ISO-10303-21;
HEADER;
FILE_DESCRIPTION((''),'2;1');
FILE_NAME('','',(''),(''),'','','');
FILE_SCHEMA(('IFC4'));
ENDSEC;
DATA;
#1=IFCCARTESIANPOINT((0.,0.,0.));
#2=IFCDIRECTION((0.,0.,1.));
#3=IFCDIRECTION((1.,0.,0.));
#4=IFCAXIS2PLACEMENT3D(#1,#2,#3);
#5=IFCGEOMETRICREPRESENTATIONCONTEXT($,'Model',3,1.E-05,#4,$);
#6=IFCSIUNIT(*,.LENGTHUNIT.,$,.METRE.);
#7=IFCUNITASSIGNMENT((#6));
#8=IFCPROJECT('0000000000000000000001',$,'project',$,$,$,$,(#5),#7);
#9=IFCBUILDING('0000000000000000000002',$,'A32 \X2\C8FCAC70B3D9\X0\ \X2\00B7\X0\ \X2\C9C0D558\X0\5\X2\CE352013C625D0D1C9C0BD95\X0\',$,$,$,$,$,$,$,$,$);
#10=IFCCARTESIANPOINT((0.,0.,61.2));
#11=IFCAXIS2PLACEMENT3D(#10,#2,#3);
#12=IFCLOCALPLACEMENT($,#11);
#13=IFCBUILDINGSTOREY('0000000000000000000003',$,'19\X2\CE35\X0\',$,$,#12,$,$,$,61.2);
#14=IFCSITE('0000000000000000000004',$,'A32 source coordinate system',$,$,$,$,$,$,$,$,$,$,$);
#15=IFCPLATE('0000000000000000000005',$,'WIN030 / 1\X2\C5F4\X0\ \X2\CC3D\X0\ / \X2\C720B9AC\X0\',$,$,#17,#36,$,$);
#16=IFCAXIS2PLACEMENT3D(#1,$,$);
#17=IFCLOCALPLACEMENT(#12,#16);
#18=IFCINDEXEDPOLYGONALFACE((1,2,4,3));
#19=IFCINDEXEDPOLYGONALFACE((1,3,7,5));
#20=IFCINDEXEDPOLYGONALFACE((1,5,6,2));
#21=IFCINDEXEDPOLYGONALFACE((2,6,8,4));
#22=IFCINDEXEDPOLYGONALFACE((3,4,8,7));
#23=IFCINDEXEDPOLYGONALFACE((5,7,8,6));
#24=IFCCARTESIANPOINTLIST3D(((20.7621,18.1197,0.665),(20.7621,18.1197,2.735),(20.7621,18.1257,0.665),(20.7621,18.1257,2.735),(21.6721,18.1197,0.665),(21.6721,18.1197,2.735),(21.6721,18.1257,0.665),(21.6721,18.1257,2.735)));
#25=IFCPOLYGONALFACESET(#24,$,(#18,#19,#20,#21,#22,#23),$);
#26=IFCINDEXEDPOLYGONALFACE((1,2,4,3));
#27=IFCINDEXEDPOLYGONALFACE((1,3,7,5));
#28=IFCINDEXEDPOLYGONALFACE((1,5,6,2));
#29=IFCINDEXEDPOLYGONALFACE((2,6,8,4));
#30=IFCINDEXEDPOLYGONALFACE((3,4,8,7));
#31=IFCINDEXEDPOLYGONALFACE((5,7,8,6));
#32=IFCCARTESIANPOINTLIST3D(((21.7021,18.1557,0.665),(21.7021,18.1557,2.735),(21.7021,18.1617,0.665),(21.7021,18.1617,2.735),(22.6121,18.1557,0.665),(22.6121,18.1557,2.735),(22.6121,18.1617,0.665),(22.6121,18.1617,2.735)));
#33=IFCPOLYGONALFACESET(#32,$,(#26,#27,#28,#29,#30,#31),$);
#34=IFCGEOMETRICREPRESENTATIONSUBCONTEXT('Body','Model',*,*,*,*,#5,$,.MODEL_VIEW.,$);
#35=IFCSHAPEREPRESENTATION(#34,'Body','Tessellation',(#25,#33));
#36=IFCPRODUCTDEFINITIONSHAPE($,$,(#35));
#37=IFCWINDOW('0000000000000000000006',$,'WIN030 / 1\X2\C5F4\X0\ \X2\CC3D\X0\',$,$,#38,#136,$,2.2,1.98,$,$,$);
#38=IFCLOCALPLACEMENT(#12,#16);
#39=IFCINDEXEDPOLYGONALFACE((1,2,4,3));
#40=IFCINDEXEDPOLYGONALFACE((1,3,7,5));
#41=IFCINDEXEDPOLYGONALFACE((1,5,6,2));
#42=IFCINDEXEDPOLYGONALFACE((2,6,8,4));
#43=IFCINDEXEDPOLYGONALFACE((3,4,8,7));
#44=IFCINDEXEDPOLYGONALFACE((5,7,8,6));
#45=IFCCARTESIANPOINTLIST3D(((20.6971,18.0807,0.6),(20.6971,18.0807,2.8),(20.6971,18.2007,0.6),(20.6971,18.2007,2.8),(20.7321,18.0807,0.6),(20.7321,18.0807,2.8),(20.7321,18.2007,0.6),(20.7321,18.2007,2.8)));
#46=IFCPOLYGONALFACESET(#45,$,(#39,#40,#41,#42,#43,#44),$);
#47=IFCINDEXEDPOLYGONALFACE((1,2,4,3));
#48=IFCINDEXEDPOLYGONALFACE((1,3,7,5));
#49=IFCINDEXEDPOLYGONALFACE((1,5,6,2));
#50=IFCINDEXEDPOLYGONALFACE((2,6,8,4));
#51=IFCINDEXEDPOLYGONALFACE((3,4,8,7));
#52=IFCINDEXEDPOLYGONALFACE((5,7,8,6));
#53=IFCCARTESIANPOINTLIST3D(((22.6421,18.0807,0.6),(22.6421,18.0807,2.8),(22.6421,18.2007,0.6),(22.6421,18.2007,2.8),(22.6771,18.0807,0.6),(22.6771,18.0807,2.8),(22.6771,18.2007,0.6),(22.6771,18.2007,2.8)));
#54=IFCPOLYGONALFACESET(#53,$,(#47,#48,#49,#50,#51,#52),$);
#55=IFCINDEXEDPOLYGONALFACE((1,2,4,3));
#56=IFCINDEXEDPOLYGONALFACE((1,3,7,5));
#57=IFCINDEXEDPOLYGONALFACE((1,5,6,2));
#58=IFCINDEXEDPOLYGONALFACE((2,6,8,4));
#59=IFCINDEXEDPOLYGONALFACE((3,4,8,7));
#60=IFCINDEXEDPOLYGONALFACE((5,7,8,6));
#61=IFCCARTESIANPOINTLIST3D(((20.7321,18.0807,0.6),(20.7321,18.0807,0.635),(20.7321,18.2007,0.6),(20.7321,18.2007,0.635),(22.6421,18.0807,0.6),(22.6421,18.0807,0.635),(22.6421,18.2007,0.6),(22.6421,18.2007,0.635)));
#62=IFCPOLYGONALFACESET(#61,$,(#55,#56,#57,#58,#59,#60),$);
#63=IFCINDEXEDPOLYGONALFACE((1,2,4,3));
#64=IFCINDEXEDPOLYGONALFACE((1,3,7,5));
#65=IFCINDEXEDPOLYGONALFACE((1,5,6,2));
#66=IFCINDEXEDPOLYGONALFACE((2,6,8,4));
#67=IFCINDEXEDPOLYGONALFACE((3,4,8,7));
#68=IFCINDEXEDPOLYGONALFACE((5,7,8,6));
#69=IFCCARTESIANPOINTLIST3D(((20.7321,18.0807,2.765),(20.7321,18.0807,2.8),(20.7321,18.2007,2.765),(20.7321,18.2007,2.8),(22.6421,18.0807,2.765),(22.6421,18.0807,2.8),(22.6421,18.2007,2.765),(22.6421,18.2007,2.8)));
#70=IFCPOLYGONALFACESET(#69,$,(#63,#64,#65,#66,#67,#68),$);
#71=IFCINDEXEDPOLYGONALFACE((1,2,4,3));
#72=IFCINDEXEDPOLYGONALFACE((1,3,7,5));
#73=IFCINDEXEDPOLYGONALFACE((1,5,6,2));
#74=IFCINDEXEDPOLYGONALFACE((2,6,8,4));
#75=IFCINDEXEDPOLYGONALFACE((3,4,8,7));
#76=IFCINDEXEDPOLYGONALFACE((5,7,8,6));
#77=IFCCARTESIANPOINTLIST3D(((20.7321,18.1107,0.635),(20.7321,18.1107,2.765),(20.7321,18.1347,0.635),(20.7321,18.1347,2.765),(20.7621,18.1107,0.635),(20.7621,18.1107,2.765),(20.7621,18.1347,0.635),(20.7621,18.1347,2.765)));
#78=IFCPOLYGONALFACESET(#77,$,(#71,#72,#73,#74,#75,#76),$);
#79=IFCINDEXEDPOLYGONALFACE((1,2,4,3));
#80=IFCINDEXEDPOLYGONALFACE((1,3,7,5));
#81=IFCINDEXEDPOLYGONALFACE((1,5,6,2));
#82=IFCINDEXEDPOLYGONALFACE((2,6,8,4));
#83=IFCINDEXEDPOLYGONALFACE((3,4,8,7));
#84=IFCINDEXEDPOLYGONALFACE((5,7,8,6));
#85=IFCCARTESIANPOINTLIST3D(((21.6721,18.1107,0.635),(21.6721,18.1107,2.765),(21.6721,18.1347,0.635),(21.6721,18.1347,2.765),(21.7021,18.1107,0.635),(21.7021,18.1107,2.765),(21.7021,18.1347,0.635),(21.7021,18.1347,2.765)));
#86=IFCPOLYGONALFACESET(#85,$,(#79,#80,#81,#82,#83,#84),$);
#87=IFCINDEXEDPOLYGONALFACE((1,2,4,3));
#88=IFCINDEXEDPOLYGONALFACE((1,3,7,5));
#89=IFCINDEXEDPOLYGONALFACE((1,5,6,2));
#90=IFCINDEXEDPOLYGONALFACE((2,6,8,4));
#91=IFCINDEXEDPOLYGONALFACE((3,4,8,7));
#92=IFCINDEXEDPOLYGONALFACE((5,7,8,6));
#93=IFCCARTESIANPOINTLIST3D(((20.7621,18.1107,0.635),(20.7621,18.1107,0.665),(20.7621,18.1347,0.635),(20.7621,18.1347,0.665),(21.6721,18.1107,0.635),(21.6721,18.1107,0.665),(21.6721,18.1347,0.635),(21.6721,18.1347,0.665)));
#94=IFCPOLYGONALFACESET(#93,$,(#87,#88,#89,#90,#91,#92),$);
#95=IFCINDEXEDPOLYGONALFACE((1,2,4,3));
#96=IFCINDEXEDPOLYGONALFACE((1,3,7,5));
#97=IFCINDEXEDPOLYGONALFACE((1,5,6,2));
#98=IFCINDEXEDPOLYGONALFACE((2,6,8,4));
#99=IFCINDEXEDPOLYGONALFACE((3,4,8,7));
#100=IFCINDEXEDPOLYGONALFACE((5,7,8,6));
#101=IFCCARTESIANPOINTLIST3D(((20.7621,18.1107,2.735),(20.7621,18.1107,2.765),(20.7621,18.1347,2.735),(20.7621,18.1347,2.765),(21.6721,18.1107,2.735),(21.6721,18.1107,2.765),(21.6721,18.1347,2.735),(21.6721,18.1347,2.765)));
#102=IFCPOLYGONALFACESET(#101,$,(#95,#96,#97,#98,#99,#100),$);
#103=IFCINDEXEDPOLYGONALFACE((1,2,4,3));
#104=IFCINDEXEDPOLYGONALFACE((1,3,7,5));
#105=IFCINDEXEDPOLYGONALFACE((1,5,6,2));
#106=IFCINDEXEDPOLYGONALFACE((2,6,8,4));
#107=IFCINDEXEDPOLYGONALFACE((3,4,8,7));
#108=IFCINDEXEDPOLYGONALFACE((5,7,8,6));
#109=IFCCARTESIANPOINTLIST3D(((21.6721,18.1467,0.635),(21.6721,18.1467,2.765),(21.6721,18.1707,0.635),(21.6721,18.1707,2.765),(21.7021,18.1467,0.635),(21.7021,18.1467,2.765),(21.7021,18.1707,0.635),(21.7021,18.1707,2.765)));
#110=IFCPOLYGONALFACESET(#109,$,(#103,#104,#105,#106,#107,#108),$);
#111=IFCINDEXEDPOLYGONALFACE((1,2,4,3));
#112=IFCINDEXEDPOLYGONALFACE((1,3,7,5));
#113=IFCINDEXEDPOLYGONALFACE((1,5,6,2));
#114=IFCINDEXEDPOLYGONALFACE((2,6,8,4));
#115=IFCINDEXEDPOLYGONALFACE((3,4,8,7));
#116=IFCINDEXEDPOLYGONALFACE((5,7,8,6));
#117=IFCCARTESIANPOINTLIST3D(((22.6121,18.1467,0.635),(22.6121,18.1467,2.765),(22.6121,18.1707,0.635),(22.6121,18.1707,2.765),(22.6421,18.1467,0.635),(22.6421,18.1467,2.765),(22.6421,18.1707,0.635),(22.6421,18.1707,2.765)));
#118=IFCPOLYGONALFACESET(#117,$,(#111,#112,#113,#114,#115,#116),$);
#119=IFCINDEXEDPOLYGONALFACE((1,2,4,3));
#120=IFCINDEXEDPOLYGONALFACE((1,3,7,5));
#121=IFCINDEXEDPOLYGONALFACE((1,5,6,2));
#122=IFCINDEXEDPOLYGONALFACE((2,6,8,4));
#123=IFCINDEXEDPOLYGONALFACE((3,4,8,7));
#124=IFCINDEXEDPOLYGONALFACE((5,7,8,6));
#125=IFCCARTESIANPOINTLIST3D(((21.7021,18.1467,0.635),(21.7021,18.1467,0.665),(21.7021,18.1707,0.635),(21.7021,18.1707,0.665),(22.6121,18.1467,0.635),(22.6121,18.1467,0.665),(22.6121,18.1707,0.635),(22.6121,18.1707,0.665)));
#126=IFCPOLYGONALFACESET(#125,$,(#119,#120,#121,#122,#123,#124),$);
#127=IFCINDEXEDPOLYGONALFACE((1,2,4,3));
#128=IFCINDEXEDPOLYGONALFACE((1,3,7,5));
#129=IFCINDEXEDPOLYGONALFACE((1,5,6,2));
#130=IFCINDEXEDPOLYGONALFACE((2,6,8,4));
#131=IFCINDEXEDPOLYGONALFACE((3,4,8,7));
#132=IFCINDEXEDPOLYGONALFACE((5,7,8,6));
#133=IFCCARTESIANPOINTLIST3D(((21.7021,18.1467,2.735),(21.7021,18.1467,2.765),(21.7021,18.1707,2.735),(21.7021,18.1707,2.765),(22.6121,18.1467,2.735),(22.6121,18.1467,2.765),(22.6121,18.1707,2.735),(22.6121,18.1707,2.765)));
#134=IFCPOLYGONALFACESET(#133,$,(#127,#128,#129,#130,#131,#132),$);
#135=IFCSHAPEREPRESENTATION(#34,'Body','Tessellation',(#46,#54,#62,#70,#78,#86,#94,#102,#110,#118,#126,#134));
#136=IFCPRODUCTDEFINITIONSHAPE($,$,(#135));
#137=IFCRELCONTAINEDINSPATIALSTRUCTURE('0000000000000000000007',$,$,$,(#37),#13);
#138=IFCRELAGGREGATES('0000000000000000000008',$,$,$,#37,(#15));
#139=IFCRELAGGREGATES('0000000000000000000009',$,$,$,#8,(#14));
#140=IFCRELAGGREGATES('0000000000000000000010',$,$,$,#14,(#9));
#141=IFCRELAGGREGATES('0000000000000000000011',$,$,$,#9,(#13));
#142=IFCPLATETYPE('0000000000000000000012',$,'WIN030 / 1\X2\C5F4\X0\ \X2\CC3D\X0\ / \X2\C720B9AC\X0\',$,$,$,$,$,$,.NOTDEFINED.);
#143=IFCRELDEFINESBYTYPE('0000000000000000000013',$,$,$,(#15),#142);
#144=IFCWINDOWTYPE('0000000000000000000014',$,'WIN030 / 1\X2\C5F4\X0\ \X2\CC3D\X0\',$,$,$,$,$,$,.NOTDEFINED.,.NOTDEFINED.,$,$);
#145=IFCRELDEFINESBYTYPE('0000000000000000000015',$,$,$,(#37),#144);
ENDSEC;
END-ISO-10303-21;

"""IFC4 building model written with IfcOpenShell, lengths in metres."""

from ifc_helpers import new_model, si_unit, frame, origin, origin_with_axes, place, context, subcontext, project, spatial, polyline, outline, extrude, source, transform, mapped, type_object, type_shapes, element, aggregate, save


model = new_model("IFC4")

# Units and contexts
model_context = context("Model", 3, precision=1e-05, world=origin_with_axes())
body_context = subcontext(model_context, "Body", "Model", "MODEL_VIEW")
ifc_project = project(units=[si_unit("LENGTHUNIT", "METRE")], contexts=[model_context])

# Plate
storey_placement = place(None, frame((0.0, 0.0, 61.2), z_axis=(0.0, 0.0, 1.0), x_axis=(1.0, 0.0, 0.0)))
plate_type_1 = type_object("IfcPlateType", Name="WIN030 / 1열 창 / 유리", PredefinedType="NOTDEFINED")
shared_shape_1 = source(origin(), body_context, "Body", "SweptSolid", [
    extrude(outline(polyline([(20.7621, 18.1197), (20.7621, 18.1257), (21.6721, 18.1257), (21.6721, 18.1197), (20.7621, 18.1197)])), frame((0.0, 0.0, 0.665)), (0.0, 0.0, 1.0), 2.07),
    extrude(outline(polyline([(21.7021, 18.1557), (21.7021, 18.1617), (22.6121, 18.1617), (22.6121, 18.1557), (21.7021, 18.1557)])), frame((0.0, 0.0, 0.665)), (0.0, 0.0, 1.0), 2.07),
])
type_shapes(plate_type_1, [shared_shape_1])
window_1_placement = place(storey_placement, origin_with_axes())
plate_1_placement = place(window_1_placement, origin_with_axes())
plate_1 = element("IfcPlate", 1, at=plate_1_placement, type_object=plate_type_1, Name="WIN030 / 1열 창 / 유리", context=body_context, shape_type="MappedRepresentation", body=[
    mapped(shared_shape_1, transform((0.0, 0.0, 0.0), scale=1.0)),
])

# Site, building, storey
site = spatial("IfcSite", under=ifc_project, Name="A32 source coordinate system")
building = spatial("IfcBuilding", under=site, Name="A32 주거동 · 지하5층–옥탑지붕")
storey = spatial("IfcBuildingStorey", under=building, at=storey_placement, Name="19층", Elevation=61.2)

# Window
window_type_1 = type_object("IfcWindowType", Name="WIN030 / 1열 창", PartitioningType="NOTDEFINED", PredefinedType="NOTDEFINED")
shared_shape_2 = source(origin(), body_context, "Body", "SweptSolid", [
    extrude(outline(polyline([(20.6971, 18.0807), (20.6971, 18.2007), (20.7321, 18.2007), (20.7321, 18.0807), (20.6971, 18.0807)])), frame((0.0, 0.0, 0.6)), (0.0, 0.0, 1.0), 2.2),
    extrude(outline(polyline([(22.6421, 18.0807), (22.6421, 18.2007), (22.6771, 18.2007), (22.6771, 18.0807), (22.6421, 18.0807)])), frame((0.0, 0.0, 0.6)), (0.0, 0.0, 1.0), 2.2),
    extrude(outline(polyline([(20.7321, 18.0807), (20.7321, 18.2007), (22.6421, 18.2007), (22.6421, 18.0807), (20.7321, 18.0807)])), frame((0.0, 0.0, 0.6)), (0.0, 0.0, 1.0), 0.035),
    extrude(outline(polyline([(20.7321, 18.0807), (20.7321, 18.2007), (22.6421, 18.2007), (22.6421, 18.0807), (20.7321, 18.0807)])), frame((0.0, 0.0, 2.765)), (0.0, 0.0, 1.0), 0.035),
    extrude(outline(polyline([(20.7321, 18.1107), (20.7321, 18.1347), (20.7621, 18.1347), (20.7621, 18.1107), (20.7321, 18.1107)])), frame((0.0, 0.0, 0.635)), (0.0, 0.0, 1.0), 2.13),
    extrude(outline(polyline([(21.6721, 18.1107), (21.6721, 18.1347), (21.7021, 18.1347), (21.7021, 18.1107), (21.6721, 18.1107)])), frame((0.0, 0.0, 0.635)), (0.0, 0.0, 1.0), 2.13),
    extrude(outline(polyline([(20.7621, 18.1107), (20.7621, 18.1347), (21.6721, 18.1347), (21.6721, 18.1107), (20.7621, 18.1107)])), frame((0.0, 0.0, 0.635)), (0.0, 0.0, 1.0), 0.03),
    extrude(outline(polyline([(20.7621, 18.1107), (20.7621, 18.1347), (21.6721, 18.1347), (21.6721, 18.1107), (20.7621, 18.1107)])), frame((0.0, 0.0, 2.735)), (0.0, 0.0, 1.0), 0.03),
    extrude(outline(polyline([(21.6721, 18.1467), (21.6721, 18.1707), (21.7021, 18.1707), (21.7021, 18.1467), (21.6721, 18.1467)])), frame((0.0, 0.0, 0.635)), (0.0, 0.0, 1.0), 2.13),
    extrude(outline(polyline([(22.6121, 18.1467), (22.6121, 18.1707), (22.6421, 18.1707), (22.6421, 18.1467), (22.6121, 18.1467)])), frame((0.0, 0.0, 0.635)), (0.0, 0.0, 1.0), 2.13),
    extrude(outline(polyline([(21.7021, 18.1467), (21.7021, 18.1707), (22.6121, 18.1707), (22.6121, 18.1467), (21.7021, 18.1467)])), frame((0.0, 0.0, 0.635)), (0.0, 0.0, 1.0), 0.03),
    extrude(outline(polyline([(21.7021, 18.1467), (21.7021, 18.1707), (22.6121, 18.1707), (22.6121, 18.1467), (21.7021, 18.1467)])), frame((0.0, 0.0, 2.735)), (0.0, 0.0, 1.0), 0.03),
])
type_shapes(window_type_1, [shared_shape_2])
window_1 = element("IfcWindow", 2, at=window_1_placement, inside=storey, type_object=window_type_1, Name="WIN030 / 1열 창", OverallHeight=2.2, OverallWidth=1.98, context=body_context, shape_type="MappedRepresentation", body=[
    mapped(shared_shape_2, transform((0.0, 0.0, 0.0), scale=1.0)),
])
aggregate(window_1, [plate_1])

save(model, "model.ifc")
